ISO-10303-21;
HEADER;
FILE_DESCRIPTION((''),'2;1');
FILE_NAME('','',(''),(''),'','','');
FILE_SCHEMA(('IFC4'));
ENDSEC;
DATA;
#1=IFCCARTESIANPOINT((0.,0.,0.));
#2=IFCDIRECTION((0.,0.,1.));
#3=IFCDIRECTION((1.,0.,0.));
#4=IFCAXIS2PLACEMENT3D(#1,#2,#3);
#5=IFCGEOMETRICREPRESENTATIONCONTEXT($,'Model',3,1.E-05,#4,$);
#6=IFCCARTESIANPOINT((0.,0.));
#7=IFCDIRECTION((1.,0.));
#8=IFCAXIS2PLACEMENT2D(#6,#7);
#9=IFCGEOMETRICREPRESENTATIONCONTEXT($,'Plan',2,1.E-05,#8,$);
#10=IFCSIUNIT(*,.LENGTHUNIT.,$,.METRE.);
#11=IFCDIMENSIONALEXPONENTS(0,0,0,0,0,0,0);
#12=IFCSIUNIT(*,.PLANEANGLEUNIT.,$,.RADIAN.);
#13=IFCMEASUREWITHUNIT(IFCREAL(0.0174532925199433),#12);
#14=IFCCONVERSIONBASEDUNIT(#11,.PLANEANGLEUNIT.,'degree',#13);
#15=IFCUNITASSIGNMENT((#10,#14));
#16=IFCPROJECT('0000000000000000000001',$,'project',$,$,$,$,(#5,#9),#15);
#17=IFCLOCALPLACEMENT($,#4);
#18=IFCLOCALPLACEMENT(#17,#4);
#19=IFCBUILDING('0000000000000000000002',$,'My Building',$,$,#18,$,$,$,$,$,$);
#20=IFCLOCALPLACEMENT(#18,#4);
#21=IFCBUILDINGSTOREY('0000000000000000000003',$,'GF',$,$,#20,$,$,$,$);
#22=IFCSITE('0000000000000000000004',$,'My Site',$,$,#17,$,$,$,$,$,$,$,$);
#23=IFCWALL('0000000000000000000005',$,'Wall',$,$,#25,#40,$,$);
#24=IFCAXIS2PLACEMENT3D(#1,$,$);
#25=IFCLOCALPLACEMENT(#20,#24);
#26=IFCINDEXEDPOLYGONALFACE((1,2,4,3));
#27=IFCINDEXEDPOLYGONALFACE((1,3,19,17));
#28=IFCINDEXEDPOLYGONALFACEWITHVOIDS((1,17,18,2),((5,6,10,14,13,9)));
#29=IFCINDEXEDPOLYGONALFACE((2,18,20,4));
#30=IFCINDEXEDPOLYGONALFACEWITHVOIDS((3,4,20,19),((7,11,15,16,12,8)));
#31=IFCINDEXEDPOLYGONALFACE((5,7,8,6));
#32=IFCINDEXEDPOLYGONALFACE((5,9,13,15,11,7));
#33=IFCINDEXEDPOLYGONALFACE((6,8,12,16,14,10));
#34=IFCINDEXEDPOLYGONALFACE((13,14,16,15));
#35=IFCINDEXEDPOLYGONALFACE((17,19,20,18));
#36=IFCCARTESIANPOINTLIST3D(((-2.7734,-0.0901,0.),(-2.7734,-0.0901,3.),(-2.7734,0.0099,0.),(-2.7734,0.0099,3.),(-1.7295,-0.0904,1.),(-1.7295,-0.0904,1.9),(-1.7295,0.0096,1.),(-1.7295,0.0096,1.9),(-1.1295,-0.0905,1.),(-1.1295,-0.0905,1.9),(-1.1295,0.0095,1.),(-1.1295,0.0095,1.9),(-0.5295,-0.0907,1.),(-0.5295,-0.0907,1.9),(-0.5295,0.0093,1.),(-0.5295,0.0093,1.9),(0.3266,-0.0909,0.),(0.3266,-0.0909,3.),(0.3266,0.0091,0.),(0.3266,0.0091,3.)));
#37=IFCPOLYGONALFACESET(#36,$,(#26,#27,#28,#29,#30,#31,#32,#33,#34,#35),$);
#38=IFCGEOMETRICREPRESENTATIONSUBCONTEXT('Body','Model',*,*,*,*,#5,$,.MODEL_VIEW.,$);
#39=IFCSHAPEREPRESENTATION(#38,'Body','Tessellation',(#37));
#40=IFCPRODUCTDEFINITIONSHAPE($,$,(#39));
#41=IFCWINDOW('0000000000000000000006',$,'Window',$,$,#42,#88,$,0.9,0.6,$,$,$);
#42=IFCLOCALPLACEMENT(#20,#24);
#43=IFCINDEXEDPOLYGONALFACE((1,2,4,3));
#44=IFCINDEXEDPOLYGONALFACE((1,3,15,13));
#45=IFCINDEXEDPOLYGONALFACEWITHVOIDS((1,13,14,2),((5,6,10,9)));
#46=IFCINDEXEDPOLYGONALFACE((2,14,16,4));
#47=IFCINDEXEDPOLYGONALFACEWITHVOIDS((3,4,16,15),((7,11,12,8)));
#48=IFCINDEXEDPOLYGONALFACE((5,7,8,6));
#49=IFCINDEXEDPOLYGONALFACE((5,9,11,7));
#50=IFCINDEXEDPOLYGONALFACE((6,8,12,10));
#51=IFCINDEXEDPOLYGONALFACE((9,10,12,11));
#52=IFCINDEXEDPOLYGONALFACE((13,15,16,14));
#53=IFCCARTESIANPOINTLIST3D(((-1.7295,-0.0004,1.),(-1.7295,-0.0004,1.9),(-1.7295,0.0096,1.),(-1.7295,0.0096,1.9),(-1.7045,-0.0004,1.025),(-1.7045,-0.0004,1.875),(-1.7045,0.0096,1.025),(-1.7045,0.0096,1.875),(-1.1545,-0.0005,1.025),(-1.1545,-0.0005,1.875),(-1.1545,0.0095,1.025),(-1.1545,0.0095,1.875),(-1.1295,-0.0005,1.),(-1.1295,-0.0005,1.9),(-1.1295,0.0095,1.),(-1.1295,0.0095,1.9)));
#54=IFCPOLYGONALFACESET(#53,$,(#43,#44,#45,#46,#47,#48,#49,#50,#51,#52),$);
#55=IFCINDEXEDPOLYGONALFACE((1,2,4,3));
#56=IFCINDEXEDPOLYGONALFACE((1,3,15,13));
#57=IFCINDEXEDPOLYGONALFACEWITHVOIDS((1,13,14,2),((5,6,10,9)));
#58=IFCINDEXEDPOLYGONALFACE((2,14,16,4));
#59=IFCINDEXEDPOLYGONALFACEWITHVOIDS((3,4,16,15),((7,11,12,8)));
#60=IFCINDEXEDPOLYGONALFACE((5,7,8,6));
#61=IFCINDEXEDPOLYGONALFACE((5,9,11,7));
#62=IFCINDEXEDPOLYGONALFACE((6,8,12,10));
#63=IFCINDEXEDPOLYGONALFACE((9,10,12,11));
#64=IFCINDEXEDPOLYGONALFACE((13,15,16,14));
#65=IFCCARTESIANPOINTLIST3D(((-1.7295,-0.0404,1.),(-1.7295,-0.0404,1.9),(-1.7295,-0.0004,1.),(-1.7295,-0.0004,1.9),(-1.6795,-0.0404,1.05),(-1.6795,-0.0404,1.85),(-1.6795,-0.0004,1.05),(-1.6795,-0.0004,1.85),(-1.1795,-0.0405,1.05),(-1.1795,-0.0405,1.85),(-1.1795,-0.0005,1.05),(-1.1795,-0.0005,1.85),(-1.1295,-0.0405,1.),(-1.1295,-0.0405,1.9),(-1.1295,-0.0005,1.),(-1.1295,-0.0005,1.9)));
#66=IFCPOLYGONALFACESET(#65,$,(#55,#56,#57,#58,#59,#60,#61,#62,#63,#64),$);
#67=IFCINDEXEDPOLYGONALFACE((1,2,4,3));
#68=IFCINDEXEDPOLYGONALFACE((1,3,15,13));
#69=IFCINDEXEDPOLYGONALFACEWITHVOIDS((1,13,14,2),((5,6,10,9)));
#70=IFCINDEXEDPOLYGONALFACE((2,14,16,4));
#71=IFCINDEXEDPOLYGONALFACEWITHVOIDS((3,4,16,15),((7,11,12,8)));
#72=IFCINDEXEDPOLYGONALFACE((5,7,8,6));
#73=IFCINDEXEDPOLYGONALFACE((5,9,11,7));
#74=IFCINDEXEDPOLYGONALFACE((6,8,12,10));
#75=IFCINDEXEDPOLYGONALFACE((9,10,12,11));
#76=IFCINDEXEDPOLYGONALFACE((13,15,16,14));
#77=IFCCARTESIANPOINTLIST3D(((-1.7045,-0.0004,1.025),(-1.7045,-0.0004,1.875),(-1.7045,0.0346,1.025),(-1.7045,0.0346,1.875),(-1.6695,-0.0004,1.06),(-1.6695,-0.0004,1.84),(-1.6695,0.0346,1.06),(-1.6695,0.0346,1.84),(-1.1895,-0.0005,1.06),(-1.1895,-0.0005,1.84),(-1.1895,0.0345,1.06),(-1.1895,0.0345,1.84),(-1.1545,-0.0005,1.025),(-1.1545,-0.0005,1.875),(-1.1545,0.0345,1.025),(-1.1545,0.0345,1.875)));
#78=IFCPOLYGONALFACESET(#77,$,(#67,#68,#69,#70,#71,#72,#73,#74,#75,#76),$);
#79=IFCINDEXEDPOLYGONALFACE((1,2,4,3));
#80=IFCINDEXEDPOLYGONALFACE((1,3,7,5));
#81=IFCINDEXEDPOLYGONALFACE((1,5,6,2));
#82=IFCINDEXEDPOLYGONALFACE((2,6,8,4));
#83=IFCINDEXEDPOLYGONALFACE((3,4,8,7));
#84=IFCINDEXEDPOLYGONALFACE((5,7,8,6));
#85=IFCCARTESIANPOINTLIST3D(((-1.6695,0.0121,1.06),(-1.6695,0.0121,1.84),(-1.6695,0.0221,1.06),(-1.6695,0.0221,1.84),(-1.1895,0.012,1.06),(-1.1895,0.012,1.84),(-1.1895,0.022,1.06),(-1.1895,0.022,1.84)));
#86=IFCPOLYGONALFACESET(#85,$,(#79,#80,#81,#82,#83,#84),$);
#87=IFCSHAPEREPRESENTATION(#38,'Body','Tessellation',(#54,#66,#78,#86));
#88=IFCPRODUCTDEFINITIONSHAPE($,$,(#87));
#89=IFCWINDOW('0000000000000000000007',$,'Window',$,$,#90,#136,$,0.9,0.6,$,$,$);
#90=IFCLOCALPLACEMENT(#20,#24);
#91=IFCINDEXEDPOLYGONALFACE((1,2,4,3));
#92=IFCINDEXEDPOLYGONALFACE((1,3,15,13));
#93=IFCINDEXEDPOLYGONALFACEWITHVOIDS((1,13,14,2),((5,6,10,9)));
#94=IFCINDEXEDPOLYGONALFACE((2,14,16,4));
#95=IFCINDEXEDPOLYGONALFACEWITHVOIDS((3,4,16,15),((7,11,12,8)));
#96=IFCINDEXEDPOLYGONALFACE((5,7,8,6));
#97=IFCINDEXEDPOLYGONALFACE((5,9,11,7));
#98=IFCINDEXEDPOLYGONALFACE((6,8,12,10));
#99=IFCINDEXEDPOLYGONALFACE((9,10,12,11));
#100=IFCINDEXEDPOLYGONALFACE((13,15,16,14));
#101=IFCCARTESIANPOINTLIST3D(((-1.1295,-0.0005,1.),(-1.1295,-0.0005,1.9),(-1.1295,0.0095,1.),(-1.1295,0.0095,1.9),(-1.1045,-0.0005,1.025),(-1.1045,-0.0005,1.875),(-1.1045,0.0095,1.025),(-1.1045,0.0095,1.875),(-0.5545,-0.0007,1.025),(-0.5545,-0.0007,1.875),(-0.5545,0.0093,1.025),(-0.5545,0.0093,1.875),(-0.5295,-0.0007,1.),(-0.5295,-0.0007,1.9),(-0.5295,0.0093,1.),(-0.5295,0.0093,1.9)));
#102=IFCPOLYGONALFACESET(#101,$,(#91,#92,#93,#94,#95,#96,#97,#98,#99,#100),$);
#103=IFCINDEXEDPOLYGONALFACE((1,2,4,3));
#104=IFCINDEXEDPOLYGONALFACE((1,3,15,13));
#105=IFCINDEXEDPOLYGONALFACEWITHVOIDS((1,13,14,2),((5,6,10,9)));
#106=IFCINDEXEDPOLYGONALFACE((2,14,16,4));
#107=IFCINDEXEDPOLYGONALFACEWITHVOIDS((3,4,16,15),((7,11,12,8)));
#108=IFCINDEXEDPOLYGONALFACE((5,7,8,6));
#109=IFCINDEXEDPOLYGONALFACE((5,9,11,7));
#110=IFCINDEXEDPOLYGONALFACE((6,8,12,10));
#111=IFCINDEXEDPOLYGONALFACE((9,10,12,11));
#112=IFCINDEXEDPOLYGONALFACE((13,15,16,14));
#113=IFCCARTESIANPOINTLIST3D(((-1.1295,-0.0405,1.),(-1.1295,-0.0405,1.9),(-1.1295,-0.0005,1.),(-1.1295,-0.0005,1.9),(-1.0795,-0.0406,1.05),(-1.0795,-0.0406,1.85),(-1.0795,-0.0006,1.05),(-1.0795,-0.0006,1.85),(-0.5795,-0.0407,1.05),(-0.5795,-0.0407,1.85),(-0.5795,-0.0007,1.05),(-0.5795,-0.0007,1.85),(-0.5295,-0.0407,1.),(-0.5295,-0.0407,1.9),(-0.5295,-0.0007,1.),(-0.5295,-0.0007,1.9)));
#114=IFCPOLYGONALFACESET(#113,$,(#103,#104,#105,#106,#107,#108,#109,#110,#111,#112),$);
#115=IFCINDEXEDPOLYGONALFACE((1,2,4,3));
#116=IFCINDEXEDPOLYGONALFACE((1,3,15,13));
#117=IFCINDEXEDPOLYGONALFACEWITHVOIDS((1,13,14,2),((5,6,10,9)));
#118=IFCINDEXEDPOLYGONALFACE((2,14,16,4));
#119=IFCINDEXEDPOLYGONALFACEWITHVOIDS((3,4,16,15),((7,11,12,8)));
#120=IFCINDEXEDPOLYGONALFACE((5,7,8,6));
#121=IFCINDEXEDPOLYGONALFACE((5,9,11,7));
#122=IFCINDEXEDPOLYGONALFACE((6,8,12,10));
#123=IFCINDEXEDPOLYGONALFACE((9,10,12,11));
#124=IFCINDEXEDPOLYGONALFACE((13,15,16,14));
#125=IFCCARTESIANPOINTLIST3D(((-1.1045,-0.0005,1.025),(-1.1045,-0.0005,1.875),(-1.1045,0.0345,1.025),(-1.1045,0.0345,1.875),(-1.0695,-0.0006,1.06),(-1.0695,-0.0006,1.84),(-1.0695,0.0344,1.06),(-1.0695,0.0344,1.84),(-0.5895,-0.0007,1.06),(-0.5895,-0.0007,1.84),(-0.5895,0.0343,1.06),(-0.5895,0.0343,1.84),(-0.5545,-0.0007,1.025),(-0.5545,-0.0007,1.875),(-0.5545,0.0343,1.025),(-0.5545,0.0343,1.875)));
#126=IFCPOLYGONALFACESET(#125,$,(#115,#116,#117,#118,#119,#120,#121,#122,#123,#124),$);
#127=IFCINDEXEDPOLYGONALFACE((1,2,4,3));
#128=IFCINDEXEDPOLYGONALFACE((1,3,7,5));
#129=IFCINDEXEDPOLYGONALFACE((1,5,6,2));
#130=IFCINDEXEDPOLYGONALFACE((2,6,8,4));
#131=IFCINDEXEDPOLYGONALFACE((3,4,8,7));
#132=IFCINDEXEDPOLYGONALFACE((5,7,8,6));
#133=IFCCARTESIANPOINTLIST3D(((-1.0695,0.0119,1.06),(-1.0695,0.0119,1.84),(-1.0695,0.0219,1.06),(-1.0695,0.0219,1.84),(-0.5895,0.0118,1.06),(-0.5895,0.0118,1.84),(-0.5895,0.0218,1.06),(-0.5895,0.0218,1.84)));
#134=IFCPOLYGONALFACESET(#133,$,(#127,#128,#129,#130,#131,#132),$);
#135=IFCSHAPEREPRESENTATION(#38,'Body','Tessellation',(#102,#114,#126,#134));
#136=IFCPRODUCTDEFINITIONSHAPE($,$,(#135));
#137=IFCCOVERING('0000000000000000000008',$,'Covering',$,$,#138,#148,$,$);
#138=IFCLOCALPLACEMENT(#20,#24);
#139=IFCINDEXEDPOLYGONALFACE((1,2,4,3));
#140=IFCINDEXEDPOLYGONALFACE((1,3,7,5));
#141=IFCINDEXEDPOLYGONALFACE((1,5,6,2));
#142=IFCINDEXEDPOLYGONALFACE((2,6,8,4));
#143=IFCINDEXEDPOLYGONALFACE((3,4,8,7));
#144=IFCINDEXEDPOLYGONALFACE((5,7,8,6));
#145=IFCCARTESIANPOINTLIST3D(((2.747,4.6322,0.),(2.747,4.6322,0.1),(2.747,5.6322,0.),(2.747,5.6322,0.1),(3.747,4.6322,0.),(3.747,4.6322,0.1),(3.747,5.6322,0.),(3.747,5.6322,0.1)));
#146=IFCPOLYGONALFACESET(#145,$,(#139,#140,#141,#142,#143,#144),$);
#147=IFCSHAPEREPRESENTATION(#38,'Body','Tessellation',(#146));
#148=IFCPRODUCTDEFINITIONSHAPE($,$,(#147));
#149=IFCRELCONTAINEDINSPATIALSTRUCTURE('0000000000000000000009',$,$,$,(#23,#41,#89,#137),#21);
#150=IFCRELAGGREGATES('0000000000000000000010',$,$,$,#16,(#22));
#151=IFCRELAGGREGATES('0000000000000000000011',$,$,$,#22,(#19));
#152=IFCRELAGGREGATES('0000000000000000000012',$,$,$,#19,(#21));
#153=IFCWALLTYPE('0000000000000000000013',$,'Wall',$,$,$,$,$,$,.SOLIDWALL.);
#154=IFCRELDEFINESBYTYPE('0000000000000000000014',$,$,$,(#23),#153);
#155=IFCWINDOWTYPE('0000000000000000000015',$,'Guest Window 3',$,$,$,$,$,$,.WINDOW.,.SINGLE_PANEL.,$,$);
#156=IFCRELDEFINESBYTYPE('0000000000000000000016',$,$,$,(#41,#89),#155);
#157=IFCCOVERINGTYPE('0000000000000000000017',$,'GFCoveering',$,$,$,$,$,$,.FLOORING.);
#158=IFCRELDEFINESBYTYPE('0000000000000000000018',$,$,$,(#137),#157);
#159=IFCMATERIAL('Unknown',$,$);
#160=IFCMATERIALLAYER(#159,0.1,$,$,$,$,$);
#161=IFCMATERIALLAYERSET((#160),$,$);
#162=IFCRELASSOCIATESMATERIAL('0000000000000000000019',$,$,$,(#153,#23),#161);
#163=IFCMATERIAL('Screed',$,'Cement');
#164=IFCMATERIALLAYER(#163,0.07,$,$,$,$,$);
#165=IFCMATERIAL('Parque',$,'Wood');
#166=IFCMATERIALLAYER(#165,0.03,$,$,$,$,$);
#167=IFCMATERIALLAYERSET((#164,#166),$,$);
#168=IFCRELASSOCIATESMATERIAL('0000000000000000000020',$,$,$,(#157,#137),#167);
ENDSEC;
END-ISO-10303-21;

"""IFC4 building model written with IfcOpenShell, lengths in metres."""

from ifc_helpers import new_model, entity, si_unit, converted_unit, frame, origin_with_axes, origin_2d_with_axis, place, context, subcontext, project, spatial, line, indexed_curve, outline, extrude, shape, source, transform, mapped, material, layer, layer_set, layer_usage, type_object, type_shapes, element, fill, save


model = new_model("IFC4")

# Units and contexts
model_context = context("Model", 3, precision=1e-05, world=origin_with_axes())
plan_context = context("Plan", 2, precision=1e-05, world=origin_2d_with_axis())
body_context_1 = subcontext(model_context, "Body", "Model", "MODEL_VIEW")
body_context_2 = subcontext(plan_context, "Body", "Plan", "PLAN_VIEW")
ifc_project = project(units=[si_unit("LENGTHUNIT", "METRE"), converted_unit("PLANEANGLEUNIT", "degree", entity("IfcReal", 0.0174532925199433), si_unit("PLANEANGLEUNIT", "RADIAN"), dimensions=[0, 0, 0, 0, 0, 0, 0])], contexts=[model_context, plan_context])

# Site, building, storey
site_placement = place(None, origin_with_axes())
site = spatial("IfcSite", under=ifc_project, at=site_placement, Name="My Site")
building_placement = place(site_placement, origin_with_axes())
building = spatial("IfcBuilding", under=site, at=building_placement, Name="My Building")
storey_placement = place(building_placement, origin_with_axes())
storey = spatial("IfcBuildingStorey", under=building, at=storey_placement, Name="GF")

# Shared definitions
ifc_material_1 = material(Name="Unknown")

# Shared definitions
ifc_layer_1 = layer(ifc_material_1, 0.1)
ifc_layer_set_1 = layer_set([ifc_layer_1])
wall_type = type_object("IfcWallType", Name="Wall", PredefinedType="SOLIDWALL", material=ifc_layer_set_1)

# Wall, openings, windows
ifc_layer_usage_1 = layer_usage(ifc_layer_set_1, "AXIS2", "POSITIVE", 0.0)
wall_1_placement = place(storey_placement, frame((-2.7734, -0.0901, 0.0), z_axis=(0.0, 0.0, 1.0), x_axis=(1.0, -0.000264, 0.0)))
wall_1 = element("IfcWall", 1, at=wall_1_placement, inside=storey, type_object=wall_type, material=ifc_layer_usage_1, Name="Wall", context=body_context_1, shape_type="SweptSolid", body=[
    extrude(outline(indexed_curve([(0.0, 0.0), (0.0, 0.1), (3.1, 0.1), (3.1, 0.0)], segments=[line(1, 2, 3, 4, 1)])), origin_with_axes(), (0.0, 0.0, 1.0), 3.0),
])
shared_shape_1 = source(origin_with_axes(), body_context_1, "Body", "SweptSolid", [
    extrude(outline(indexed_curve([(0.0, 0.0), (0.6, 0.0), (0.6, 0.9), (0.0, 0.9)], segments=[line(1, 2, 3, 4, 1)])), frame((0.0, -0.6, 0.0), z_axis=(0.0, -1.0, 0.0), x_axis=(1.0, 0.0, 0.0)), (0.0, 0.0, -1.0), 1.2),
])
opening_1_placement = place(wall_1_placement, frame((1.0439, 0.0, 1.0), z_axis=(0.0, 0.0, 1.0), x_axis=(1.0, 0.0, 0.0)))
opening_1 = element("IfcOpeningElement", 2, at=opening_1_placement, cuts=wall_1, PredefinedType="OPENING", context=body_context_1, shape_type="MappedRepresentation", body=[
    mapped(shared_shape_1, transform((0.0, 0.0, 0.0), x_axis=(1.0, 0.0, 0.0), y_axis=(0.0, 1.0, 0.0), z_axis=(0.0, 0.0, 1.0), scale=1.0)),
])
opening_2_placement = place(wall_1_placement, frame((1.6439, 0.0, 1.0), z_axis=(0.0, 0.0, 1.0), x_axis=(1.0, 0.0, 0.0)))
opening_2 = element("IfcOpeningElement", 3, at=opening_2_placement, cuts=wall_1, PredefinedType="OPENING", context=body_context_1, shape_type="MappedRepresentation", body=[
    mapped(shared_shape_1, transform((0.0, 0.0, 0.0), x_axis=(1.0, 0.0, 0.0), y_axis=(0.0, 1.0, 0.0), z_axis=(0.0, 0.0, 1.0), scale=1.0)),
])
window_type_1 = type_object("IfcWindowType", Name="Guest Window 3", PartitioningType="SINGLE_PANEL", PredefinedType="WINDOW")
shared_shape_2 = source(origin_with_axes(), body_context_1, "Body", "SweptSolid", [
    extrude(outline(indexed_curve([(0.0, 0.0), (0.6, 0.0), (0.6, 0.9), (0.0, 0.9)], segments=[line(1, 2, 3, 4, 1)]), holes=[indexed_curve([(0.025, 0.025), (0.575, 0.025), (0.575, 0.875), (0.025, 0.875)], segments=[line(1, 2, 3, 4, 1)])]), frame((0.0, 0.09, 0.0), z_axis=(0.0, -1.0, 0.0), x_axis=(1.0, 0.0, 0.0)), (0.0, 0.0, -1.0), 0.01),
    extrude(outline(indexed_curve([(0.0, 0.0), (0.6, 0.0), (0.6, 0.9), (0.0, 0.9)], segments=[line(1, 2, 3, 4, 1)]), holes=[indexed_curve([(0.05, 0.05), (0.55, 0.05), (0.55, 0.85), (0.05, 0.85)], segments=[line(1, 2, 3, 4, 1)])]), frame((0.0, 0.05, 0.0), z_axis=(0.0, -1.0, 0.0), x_axis=(1.0, 0.0, 0.0)), (0.0, 0.0, -1.0), 0.04),
    extrude(outline(indexed_curve([(0.0, 0.0), (0.55, 0.0), (0.55, 0.85), (0.0, 0.85)], segments=[line(1, 2, 3, 4, 1)]), holes=[indexed_curve([(0.035, 0.035), (0.515, 0.035), (0.515, 0.815), (0.035, 0.815)], segments=[line(1, 2, 3, 4, 1)])]), frame((0.025, 0.09, 0.025), z_axis=(0.0, -1.0, 0.0), x_axis=(1.0, 0.0, 0.0)), (0.0, 0.0, -1.0), 0.035),
    extrude(outline(indexed_curve([(0.035, 0.035), (0.515, 0.035), (0.515, 0.815), (0.035, 0.815)], segments=[line(1, 2, 3, 4, 1)])), frame((0.025, 0.1025, 0.025), z_axis=(0.0, -1.0, 0.0), x_axis=(1.0, 0.0, 0.0)), (0.0, 0.0, -1.0), 0.01),
])
shared_shape_3 = source(origin_with_axes(), body_context_2, "Body", "Curve2D", [
    entity("IfcIndexedPolyCurve", entity("IfcCartesianPointList2D", [[0.05, 0.05], [0.55, 0.05]])),
    entity("IfcIndexedPolyCurve", entity("IfcCartesianPointList2D", [[0.0, 0.1], [0.025, 0.1], [0.025, 0.09], [0.05, 0.09], [0.05, 0.05], [0.0, 0.05]]), [entity("IfcLineIndex", [1, 2, 3, 4, 5, 6, 1])]),
    entity("IfcIndexedPolyCurve", entity("IfcCartesianPointList2D", [[0.6, 0.1], [0.575, 0.1], [0.575, 0.09], [0.55, 0.09], [0.55, 0.05], [0.6, 0.05]]), [entity("IfcLineIndex", [1, 2, 3, 4, 5, 6, 1])]),
    entity("IfcIndexedPolyCurve", entity("IfcCartesianPointList2D", [[0.025, 0.09], [0.06, 0.09], [0.06, 0.125], [0.025, 0.125]]), [entity("IfcLineIndex", [1, 2, 3, 4, 1])]),
    entity("IfcIndexedPolyCurve", entity("IfcCartesianPointList2D", [[0.575, 0.09], [0.54, 0.09], [0.54, 0.125], [0.575, 0.125]]), [entity("IfcLineIndex", [1, 2, 3, 4, 1])]),
    entity("IfcIndexedPolyCurve", entity("IfcCartesianPointList2D", [[0.06, 0.09], [0.54, 0.09]])),
    entity("IfcIndexedPolyCurve", entity("IfcCartesianPointList2D", [[0.06, 0.125], [0.54, 0.125]])),
    entity("IfcIndexedPolyCurve", entity("IfcCartesianPointList2D", [[0.06, 0.1075], [0.54, 0.1075]])),
])
type_shapes(window_type_1, [shared_shape_2, shared_shape_3])
window_1_placement = place(opening_1_placement, frame((0.0, 0.0, 0.0), z_axis=(0.0, 0.0, 1.0), x_axis=(1.0, 0.0, 0.0)))
window_1 = element("IfcWindow", 4, at=window_1_placement, inside=storey, type_object=window_type_1, Name="Window", OverallHeight=0.9, OverallWidth=0.6, shapes=[
    shape(body_context_1, "Body", "MappedRepresentation", [mapped(shared_shape_2, transform((0.0, 0.0, 0.0), x_axis=(1.0, 0.0, 0.0), y_axis=(0.0, 1.0, 0.0), z_axis=(0.0, 0.0, 1.0), scale=1.0))]),
    shape(body_context_2, "Body", "MappedRepresentation", [mapped(shared_shape_3, transform((0.0, 0.0, 0.0), x_axis=(1.0, 0.0, 0.0), y_axis=(0.0, 1.0, 0.0), z_axis=(0.0, 0.0, 1.0), scale=1.0))]),
])
fill(opening_1, window_1)
window_2_placement = place(opening_2_placement, frame((0.0, 0.0, 0.0), z_axis=(0.0, 0.0, 1.0), x_axis=(1.0, 0.0, 0.0)))
window_2 = element("IfcWindow", 5, at=window_2_placement, inside=storey, type_object=window_type_1, Name="Window", OverallHeight=0.9, OverallWidth=0.6, shapes=[
    shape(body_context_1, "Body", "MappedRepresentation", [mapped(shared_shape_2, transform((0.0, 0.0, 0.0), x_axis=(1.0, 0.0, 0.0), y_axis=(0.0, 1.0, 0.0), z_axis=(0.0, 0.0, 1.0), scale=1.0))]),
    shape(body_context_2, "Body", "MappedRepresentation", [mapped(shared_shape_3, transform((0.0, 0.0, 0.0), x_axis=(1.0, 0.0, 0.0), y_axis=(0.0, 1.0, 0.0), z_axis=(0.0, 0.0, 1.0), scale=1.0))]),
])
fill(opening_2, window_2)

# Covering
ifc_material_2 = material(Name="Screed", Category="Cement")
ifc_layer_2 = layer(ifc_material_2, 0.07)
ifc_material_3 = material(Name="Parque", Category="Wood")
ifc_layer_3 = layer(ifc_material_3, 0.03)
ifc_layer_set_2 = layer_set([ifc_layer_2, ifc_layer_3])
ifc_layer_usage_2 = layer_usage(ifc_layer_set_2, "AXIS3", "POSITIVE", 0.0)
covering_type = type_object("IfcCoveringType", Name="GFCoveering", PredefinedType="FLOORING", material=ifc_layer_set_2)
covering_placement = place(storey_placement, frame((2.747, 4.6322, 0.0), z_axis=(0.0, 0.0, 1.0), x_axis=(1.0, 0.0, 0.0)))
element("IfcCovering", 6, at=covering_placement, inside=storey, type_object=covering_type, material=ifc_layer_usage_2, Name="Covering", context=body_context_1, shape_type="SweptSolid", body=[
    extrude(outline(indexed_curve([(0.0, 0.0), (1.0, 0.0), (1.0, 1.0), (0.0, 1.0), (0.0, 0.0)])), None, (0.0, 0.0, 1.0), 0.1),
])

save(model, "model.ifc")
